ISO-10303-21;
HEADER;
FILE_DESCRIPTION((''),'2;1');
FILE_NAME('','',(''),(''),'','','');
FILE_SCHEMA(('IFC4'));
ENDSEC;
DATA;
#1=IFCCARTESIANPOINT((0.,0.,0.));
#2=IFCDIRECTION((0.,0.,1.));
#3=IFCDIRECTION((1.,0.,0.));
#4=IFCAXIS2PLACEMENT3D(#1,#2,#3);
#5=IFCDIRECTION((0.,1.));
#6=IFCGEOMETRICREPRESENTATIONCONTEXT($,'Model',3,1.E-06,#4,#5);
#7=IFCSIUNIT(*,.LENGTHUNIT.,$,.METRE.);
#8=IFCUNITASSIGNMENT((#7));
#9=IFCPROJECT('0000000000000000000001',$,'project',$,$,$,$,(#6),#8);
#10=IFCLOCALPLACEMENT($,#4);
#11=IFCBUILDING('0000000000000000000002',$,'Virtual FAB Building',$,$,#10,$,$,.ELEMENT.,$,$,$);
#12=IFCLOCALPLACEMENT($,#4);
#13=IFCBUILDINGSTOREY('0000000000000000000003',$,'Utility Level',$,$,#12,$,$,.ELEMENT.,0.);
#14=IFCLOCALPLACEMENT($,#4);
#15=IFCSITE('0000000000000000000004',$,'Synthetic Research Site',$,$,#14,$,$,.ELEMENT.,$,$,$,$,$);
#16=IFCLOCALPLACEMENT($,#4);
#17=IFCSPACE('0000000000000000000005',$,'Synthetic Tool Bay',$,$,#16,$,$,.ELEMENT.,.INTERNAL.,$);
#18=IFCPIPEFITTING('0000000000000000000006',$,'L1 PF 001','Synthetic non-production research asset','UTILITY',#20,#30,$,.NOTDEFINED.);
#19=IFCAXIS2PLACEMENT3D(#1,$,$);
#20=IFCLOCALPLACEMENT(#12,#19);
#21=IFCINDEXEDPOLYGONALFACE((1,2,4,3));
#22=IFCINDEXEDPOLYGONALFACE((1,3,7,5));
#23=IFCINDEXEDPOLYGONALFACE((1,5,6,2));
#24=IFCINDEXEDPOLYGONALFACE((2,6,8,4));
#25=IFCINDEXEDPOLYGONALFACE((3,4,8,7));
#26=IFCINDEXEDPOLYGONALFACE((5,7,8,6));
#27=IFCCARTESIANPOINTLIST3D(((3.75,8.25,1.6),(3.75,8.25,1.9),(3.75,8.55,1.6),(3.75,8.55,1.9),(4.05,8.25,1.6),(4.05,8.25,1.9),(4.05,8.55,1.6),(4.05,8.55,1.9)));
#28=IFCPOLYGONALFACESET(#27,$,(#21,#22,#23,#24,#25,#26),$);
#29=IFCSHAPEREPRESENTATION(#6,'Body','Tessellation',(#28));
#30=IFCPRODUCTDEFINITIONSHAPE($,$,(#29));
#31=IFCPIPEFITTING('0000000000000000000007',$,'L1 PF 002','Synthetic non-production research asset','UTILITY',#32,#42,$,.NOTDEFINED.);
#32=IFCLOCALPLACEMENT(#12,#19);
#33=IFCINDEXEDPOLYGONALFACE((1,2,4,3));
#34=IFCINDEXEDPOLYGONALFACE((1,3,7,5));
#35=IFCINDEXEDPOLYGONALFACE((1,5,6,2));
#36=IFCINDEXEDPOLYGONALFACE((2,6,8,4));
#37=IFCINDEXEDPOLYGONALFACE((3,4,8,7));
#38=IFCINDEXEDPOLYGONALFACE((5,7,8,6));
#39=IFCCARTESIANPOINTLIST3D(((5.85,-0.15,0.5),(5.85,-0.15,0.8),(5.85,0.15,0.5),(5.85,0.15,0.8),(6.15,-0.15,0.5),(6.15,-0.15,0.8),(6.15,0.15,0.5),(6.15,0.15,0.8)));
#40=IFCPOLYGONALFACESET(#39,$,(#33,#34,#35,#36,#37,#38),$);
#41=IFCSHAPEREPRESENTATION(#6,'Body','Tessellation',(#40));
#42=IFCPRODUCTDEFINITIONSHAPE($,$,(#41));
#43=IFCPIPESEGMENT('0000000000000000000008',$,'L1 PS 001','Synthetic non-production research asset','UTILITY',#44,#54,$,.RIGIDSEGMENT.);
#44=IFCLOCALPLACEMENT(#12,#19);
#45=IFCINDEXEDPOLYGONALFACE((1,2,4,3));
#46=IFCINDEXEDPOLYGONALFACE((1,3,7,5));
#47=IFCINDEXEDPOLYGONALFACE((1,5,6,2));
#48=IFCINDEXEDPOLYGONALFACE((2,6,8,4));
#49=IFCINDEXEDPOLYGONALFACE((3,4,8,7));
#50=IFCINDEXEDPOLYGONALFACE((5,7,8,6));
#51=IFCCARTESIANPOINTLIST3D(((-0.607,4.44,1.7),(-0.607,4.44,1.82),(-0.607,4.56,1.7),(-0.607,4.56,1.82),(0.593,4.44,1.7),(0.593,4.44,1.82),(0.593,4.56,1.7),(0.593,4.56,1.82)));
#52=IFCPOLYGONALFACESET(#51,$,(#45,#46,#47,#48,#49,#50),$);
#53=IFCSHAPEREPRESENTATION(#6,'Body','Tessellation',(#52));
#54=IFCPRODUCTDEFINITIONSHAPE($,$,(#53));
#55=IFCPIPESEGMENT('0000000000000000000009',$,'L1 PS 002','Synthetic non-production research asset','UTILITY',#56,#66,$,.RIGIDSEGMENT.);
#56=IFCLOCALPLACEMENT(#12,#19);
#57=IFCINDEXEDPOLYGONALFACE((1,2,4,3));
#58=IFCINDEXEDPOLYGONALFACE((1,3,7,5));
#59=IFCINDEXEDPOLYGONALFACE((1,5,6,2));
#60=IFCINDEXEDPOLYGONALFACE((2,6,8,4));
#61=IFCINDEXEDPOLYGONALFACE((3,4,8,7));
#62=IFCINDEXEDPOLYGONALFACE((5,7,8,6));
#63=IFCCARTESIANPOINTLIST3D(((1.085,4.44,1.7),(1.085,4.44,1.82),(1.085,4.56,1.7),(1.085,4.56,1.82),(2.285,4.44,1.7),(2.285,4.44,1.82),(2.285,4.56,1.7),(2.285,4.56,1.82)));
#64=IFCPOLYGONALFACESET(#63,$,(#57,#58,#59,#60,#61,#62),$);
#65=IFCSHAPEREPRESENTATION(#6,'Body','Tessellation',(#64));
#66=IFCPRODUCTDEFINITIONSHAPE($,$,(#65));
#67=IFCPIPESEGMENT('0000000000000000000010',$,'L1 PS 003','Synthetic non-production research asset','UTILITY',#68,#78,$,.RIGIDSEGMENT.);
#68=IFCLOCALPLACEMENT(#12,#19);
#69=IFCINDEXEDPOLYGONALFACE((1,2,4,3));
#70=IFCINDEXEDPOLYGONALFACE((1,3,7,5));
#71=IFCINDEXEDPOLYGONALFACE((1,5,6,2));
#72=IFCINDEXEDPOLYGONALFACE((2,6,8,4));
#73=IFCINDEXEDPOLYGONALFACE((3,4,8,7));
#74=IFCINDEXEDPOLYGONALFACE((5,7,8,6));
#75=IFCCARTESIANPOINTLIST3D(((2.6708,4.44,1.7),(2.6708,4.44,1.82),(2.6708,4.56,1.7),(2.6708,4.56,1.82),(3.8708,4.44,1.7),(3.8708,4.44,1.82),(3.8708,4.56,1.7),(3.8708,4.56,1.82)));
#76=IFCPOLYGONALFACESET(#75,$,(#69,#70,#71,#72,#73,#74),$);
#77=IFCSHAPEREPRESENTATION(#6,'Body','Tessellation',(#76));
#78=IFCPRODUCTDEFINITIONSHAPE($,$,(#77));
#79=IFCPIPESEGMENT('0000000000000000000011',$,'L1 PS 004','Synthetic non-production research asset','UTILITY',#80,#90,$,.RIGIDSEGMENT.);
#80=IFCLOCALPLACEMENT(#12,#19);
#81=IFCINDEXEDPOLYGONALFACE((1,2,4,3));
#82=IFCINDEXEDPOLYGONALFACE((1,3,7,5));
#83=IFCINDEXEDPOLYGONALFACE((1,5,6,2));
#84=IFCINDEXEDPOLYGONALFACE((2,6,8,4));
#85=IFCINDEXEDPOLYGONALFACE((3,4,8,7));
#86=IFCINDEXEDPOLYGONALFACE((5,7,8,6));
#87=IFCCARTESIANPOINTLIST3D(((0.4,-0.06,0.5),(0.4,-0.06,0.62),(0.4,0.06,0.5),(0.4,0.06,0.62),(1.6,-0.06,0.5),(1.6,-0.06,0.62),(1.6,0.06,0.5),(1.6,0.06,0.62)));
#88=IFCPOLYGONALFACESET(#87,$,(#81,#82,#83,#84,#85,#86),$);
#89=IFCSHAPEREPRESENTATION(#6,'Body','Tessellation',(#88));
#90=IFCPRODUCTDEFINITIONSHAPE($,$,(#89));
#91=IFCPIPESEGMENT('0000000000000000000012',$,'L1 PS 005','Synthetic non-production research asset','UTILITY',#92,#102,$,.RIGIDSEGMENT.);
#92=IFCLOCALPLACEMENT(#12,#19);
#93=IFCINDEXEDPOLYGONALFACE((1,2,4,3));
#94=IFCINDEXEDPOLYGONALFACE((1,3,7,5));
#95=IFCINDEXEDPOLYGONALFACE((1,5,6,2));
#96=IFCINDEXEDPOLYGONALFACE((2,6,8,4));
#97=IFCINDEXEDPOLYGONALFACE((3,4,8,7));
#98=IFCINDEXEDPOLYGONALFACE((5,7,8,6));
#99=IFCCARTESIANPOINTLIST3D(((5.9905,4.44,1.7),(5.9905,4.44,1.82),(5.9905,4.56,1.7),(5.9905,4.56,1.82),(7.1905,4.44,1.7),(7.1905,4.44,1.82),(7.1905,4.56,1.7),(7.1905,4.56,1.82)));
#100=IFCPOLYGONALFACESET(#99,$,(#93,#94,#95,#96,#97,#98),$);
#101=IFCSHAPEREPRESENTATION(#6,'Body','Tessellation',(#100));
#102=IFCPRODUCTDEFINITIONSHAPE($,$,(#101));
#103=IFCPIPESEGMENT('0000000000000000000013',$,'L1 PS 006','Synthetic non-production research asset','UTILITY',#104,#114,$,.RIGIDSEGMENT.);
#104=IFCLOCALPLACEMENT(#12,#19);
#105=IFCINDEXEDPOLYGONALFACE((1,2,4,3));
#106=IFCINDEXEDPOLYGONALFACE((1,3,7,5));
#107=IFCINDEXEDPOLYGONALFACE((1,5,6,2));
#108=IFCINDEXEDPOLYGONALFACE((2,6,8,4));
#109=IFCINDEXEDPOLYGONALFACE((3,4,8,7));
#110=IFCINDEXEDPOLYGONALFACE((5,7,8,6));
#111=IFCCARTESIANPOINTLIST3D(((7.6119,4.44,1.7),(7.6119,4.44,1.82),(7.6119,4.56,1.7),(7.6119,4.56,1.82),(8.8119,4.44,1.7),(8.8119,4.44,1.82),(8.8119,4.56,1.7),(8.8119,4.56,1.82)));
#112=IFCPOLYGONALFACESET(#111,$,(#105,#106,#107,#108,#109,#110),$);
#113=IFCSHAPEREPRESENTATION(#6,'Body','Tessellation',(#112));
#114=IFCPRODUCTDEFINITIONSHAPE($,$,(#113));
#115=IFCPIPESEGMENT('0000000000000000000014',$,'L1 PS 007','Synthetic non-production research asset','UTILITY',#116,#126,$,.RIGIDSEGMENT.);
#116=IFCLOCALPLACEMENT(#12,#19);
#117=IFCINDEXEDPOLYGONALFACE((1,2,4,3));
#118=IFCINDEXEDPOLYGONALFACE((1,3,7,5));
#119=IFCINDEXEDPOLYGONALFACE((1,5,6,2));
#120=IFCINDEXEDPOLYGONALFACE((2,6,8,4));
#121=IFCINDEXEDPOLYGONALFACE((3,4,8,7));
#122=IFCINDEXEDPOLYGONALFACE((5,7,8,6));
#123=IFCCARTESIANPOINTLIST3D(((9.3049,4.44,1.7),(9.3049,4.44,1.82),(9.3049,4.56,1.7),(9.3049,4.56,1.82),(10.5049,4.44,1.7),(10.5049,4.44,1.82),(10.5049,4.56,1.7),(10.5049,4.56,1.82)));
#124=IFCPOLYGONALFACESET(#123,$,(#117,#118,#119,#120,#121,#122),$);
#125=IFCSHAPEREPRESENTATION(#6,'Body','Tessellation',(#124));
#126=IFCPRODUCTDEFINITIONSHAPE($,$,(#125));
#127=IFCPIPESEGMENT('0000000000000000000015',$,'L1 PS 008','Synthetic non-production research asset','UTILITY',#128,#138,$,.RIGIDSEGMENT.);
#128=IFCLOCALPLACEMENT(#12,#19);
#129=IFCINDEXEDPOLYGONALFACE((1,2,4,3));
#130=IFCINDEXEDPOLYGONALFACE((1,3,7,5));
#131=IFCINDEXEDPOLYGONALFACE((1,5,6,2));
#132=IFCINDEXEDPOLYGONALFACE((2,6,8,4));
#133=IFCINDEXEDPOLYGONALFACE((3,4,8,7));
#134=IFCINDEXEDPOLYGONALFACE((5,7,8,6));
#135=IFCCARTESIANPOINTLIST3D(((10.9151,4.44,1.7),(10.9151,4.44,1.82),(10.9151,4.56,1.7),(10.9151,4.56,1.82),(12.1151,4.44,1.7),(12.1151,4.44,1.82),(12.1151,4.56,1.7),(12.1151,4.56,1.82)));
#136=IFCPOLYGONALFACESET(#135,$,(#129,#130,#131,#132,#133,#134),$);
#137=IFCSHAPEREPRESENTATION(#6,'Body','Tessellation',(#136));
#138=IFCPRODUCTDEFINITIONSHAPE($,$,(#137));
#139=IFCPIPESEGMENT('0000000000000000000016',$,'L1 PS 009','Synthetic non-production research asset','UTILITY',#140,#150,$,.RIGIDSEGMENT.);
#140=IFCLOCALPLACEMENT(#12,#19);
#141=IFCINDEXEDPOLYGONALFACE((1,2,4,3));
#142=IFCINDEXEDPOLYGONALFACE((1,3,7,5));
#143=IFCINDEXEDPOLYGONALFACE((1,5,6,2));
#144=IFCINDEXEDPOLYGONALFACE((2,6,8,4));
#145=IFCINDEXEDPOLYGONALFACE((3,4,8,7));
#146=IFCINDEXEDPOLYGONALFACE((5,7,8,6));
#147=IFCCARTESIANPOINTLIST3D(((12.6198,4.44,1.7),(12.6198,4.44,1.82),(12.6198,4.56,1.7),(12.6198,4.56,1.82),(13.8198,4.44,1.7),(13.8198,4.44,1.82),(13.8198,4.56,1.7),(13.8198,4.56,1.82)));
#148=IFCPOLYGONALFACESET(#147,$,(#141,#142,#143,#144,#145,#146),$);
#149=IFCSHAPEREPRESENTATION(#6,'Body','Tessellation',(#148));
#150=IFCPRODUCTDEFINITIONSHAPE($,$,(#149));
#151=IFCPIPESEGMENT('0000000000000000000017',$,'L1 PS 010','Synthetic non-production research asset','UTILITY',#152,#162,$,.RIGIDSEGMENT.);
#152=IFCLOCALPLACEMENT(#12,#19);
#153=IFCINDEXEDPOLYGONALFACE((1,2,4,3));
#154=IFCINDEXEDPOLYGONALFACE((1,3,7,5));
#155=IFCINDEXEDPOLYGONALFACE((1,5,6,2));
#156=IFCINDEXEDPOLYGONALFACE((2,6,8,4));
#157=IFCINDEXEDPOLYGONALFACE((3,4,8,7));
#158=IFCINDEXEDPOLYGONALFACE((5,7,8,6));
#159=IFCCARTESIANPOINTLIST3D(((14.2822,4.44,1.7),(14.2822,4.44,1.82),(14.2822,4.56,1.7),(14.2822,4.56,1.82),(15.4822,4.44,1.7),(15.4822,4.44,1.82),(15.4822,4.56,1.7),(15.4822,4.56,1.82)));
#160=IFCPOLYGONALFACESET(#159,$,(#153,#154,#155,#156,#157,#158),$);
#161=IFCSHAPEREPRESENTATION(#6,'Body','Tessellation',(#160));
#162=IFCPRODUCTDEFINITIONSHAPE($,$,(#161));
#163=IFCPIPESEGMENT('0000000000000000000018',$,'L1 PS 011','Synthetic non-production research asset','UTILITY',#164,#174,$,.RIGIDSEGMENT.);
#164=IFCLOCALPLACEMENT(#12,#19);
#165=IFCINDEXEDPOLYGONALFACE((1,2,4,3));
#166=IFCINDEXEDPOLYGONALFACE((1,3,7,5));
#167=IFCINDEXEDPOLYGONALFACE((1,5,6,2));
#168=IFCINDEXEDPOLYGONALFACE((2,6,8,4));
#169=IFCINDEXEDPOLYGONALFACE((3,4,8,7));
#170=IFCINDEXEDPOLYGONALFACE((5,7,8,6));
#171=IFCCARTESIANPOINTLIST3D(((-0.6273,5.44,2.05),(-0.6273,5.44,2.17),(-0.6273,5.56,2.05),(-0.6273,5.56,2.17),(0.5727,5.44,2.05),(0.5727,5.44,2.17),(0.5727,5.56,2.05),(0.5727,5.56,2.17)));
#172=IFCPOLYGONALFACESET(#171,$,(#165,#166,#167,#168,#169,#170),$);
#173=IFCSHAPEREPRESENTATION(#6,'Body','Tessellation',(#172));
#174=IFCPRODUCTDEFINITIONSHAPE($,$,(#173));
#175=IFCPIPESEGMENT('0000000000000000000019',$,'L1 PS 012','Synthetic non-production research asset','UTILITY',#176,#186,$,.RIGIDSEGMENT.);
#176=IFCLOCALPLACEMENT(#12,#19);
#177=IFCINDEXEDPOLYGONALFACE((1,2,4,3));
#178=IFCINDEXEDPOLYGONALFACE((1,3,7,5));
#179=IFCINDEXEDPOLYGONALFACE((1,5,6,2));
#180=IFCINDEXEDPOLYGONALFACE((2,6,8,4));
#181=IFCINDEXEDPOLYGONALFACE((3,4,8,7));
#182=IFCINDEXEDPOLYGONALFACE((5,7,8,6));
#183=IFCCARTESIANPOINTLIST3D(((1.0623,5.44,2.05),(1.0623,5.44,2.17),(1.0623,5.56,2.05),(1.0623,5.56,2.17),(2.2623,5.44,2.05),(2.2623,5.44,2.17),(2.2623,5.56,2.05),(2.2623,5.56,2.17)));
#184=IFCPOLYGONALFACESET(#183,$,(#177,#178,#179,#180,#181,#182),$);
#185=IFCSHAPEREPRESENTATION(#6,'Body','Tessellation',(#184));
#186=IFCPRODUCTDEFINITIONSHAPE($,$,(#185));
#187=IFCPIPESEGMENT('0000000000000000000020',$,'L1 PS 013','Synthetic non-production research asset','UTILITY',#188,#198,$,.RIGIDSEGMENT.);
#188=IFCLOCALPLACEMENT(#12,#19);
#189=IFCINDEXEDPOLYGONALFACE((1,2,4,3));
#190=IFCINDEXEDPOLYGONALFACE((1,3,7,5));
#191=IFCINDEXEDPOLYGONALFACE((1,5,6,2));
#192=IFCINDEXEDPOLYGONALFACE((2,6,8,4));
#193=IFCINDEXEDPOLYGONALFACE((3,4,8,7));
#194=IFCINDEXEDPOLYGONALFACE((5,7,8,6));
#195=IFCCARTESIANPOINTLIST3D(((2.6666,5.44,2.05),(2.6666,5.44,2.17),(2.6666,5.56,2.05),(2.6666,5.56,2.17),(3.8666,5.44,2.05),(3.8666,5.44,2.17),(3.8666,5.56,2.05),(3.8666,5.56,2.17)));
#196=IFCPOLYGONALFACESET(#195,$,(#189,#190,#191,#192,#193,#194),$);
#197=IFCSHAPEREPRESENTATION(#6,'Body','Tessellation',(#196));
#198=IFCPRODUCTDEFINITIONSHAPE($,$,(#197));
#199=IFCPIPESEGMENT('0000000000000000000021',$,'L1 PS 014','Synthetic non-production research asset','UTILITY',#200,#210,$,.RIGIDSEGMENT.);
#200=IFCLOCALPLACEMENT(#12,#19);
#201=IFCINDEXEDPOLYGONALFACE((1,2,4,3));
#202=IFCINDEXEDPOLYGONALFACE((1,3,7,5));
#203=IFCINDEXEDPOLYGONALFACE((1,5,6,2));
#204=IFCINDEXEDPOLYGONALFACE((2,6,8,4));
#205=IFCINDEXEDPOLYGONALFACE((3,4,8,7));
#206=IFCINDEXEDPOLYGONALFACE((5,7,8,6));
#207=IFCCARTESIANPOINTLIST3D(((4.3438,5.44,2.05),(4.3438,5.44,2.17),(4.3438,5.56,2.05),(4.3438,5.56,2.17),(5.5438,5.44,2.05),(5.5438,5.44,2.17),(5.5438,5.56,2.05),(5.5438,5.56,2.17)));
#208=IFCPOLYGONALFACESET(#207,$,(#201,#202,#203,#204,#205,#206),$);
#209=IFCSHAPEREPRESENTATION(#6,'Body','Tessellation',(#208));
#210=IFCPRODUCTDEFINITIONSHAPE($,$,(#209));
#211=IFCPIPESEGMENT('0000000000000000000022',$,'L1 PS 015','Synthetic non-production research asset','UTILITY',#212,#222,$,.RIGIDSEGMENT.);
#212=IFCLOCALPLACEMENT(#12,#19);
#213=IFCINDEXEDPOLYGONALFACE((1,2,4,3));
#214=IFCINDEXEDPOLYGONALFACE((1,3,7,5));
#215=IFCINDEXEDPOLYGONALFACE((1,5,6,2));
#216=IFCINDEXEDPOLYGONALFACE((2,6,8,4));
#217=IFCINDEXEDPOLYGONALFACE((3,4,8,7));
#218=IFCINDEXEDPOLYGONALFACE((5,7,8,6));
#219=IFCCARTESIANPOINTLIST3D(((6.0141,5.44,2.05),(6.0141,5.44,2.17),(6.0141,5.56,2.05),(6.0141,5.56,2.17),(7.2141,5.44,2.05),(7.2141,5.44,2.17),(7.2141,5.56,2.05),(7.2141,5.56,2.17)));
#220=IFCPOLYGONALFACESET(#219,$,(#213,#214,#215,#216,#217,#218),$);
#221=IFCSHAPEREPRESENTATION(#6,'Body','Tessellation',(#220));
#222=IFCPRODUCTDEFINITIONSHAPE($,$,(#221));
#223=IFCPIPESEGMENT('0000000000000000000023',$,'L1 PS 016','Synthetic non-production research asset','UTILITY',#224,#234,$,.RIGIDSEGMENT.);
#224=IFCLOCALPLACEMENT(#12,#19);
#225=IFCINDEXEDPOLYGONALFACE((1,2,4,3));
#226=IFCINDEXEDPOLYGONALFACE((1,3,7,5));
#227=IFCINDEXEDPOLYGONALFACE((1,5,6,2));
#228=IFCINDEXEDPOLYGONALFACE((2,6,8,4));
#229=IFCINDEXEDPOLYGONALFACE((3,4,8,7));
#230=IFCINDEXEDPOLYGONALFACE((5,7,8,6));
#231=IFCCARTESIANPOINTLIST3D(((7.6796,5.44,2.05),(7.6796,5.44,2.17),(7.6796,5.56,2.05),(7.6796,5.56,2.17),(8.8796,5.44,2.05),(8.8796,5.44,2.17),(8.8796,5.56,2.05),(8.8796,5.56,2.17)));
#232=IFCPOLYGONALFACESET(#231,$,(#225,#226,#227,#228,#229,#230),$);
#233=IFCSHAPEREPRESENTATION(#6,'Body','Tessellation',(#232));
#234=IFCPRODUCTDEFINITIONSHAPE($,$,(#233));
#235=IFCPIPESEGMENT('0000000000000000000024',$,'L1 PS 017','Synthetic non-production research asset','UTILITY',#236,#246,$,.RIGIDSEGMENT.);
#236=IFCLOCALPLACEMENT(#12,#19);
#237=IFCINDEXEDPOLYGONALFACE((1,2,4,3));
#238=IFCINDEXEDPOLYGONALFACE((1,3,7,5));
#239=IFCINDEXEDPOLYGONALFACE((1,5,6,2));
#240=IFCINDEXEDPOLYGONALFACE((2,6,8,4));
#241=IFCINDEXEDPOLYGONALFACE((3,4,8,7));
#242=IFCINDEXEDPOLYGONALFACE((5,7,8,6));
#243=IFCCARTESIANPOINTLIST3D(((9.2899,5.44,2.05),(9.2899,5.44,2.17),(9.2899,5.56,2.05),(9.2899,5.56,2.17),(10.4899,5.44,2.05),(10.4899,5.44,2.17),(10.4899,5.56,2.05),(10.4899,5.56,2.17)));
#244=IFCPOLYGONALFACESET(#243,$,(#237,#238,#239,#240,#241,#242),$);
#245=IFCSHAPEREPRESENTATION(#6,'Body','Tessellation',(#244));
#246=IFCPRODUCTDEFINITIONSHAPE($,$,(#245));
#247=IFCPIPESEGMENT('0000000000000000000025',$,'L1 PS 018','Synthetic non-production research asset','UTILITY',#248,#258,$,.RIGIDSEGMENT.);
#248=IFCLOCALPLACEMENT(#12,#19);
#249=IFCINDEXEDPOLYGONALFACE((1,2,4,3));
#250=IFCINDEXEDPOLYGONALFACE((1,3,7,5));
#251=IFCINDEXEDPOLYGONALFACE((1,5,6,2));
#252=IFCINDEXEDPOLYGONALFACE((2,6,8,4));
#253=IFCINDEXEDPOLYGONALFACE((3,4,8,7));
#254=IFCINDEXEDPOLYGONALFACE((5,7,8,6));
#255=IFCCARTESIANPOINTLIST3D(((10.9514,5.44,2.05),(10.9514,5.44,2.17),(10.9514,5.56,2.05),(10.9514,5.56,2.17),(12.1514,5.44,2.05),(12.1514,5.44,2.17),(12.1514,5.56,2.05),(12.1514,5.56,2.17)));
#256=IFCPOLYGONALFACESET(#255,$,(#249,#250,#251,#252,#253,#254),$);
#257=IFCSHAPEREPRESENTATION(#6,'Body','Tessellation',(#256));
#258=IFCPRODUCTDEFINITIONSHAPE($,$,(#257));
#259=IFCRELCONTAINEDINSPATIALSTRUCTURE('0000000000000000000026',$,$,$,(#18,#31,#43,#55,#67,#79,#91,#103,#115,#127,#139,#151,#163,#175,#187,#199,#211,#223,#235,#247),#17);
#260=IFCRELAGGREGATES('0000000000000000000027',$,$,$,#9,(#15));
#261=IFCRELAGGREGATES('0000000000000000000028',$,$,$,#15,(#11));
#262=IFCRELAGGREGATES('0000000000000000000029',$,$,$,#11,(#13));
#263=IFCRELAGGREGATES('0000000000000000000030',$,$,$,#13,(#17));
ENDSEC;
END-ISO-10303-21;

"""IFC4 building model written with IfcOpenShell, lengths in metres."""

from ifc_helpers import new_model, si_unit, direction, frame, origin_with_axes, origin_2d_with_axis, place, context, project, spatial, rectangle, extrude, element, save


model = new_model("IFC4")

# Units and contexts
model_context = context("Model", 3, precision=1e-06, world=origin_with_axes(), true_north=direction((0.0, 1.0)))
ifc_project = project(units=[si_unit("LENGTHUNIT", "METRE")], contexts=[model_context])

# Site, building, storey, space
site_placement = place(None, origin_with_axes())
site = spatial("IfcSite", under=ifc_project, at=site_placement, Name="Synthetic Research Site", CompositionType="ELEMENT")
building_placement = place(None, origin_with_axes())
building = spatial("IfcBuilding", under=site, at=building_placement, Name="Virtual FAB Building", CompositionType="ELEMENT")
storey_placement = place(None, origin_with_axes())
storey = spatial("IfcBuildingStorey", under=building, at=storey_placement, Name="Utility Level", CompositionType="ELEMENT", Elevation=0.0)
space_placement = place(None, origin_with_axes())
space = spatial("IfcSpace", under=storey, at=space_placement, Name="Synthetic Tool Bay", CompositionType="ELEMENT", PredefinedType="INTERNAL")

# Pipe fittings
for number, where, z_axis, x_axis, name in (
    (1, (3.9, 8.4, 1.6), (0.0, 0.0, 1.0), (1.0, 0.0, 0.0), "L1 PF 001"),
    (2, (6.0, 0.0, 0.5), (0.0, 0.0, 1.0), (1.0, 0.0, 0.0), "L1 PF 002"),
):
    element("IfcPipeFitting", number, at=place(None, frame(where, z_axis=z_axis, x_axis=x_axis)), inside=space, Name=name, Description="Synthetic non-production research asset", ObjectType="UTILITY", PredefinedType="NOTDEFINED", context=model_context, shape_type="SweptSolid", body=[
        extrude(rectangle(XDim=0.3, YDim=0.3, at=origin_2d_with_axis()), origin_with_axes(), (0.0, 0.0, 1.0), 0.3),
    ])

# Pipe segments
for number, where, z_axis, x_axis, name in (
    (3, (-0.007, 4.5, 1.7), (0.0, 0.0, 1.0), (1.0, 0.0, 0.0), "L1 PS 001"),
    (4, (1.685, 4.5, 1.7), (0.0, 0.0, 1.0), (1.0, 0.0, 0.0), "L1 PS 002"),
    (5, (3.2708, 4.5, 1.7), (0.0, 0.0, 1.0), (1.0, 0.0, 0.0), "L1 PS 003"),
    (6, (1.0, 0.0, 0.5), (0.0, 0.0, 1.0), (1.0, 0.0, 0.0), "L1 PS 004"),
    (7, (6.5905, 4.5, 1.7), (0.0, 0.0, 1.0), (1.0, 0.0, 0.0), "L1 PS 005"),
    (8, (8.2119, 4.5, 1.7), (0.0, 0.0, 1.0), (1.0, 0.0, 0.0), "L1 PS 006"),
    (9, (9.9049, 4.5, 1.7), (0.0, 0.0, 1.0), (1.0, 0.0, 0.0), "L1 PS 007"),
    (10, (11.5151, 4.5, 1.7), (0.0, 0.0, 1.0), (1.0, 0.0, 0.0), "L1 PS 008"),
    (11, (13.2198, 4.5, 1.7), (0.0, 0.0, 1.0), (1.0, 0.0, 0.0), "L1 PS 009"),
    (12, (14.8822, 4.5, 1.7), (0.0, 0.0, 1.0), (1.0, 0.0, 0.0), "L1 PS 010"),
    (13, (-0.0273, 5.5, 2.05), (0.0, 0.0, 1.0), (1.0, 0.0, 0.0), "L1 PS 011"),
    (14, (1.6623, 5.5, 2.05), (0.0, 0.0, 1.0), (1.0, 0.0, 0.0), "L1 PS 012"),
    (15, (3.2666, 5.5, 2.05), (0.0, 0.0, 1.0), (1.0, 0.0, 0.0), "L1 PS 013"),
    (16, (4.9438, 5.5, 2.05), (0.0, 0.0, 1.0), (1.0, 0.0, 0.0), "L1 PS 014"),
    (17, (6.6141, 5.5, 2.05), (0.0, 0.0, 1.0), (1.0, 0.0, 0.0), "L1 PS 015"),
    (18, (8.2796, 5.5, 2.05), (0.0, 0.0, 1.0), (1.0, 0.0, 0.0), "L1 PS 016"),
    (19, (9.8899, 5.5, 2.05), (0.0, 0.0, 1.0), (1.0, 0.0, 0.0), "L1 PS 017"),
    (20, (11.5514, 5.5, 2.05), (0.0, 0.0, 1.0), (1.0, 0.0, 0.0), "L1 PS 018"),
):
    element("IfcPipeSegment", number, at=place(None, frame(where, z_axis=z_axis, x_axis=x_axis)), inside=space, Name=name, Description="Synthetic non-production research asset", ObjectType="UTILITY", PredefinedType="RIGIDSEGMENT", context=model_context, shape_type="SweptSolid", body=[
        extrude(rectangle(XDim=1.2, YDim=0.12, at=origin_2d_with_axis()), origin_with_axes(), (0.0, 0.0, 1.0), 0.12),
    ])

save(model, "model.ifc")
